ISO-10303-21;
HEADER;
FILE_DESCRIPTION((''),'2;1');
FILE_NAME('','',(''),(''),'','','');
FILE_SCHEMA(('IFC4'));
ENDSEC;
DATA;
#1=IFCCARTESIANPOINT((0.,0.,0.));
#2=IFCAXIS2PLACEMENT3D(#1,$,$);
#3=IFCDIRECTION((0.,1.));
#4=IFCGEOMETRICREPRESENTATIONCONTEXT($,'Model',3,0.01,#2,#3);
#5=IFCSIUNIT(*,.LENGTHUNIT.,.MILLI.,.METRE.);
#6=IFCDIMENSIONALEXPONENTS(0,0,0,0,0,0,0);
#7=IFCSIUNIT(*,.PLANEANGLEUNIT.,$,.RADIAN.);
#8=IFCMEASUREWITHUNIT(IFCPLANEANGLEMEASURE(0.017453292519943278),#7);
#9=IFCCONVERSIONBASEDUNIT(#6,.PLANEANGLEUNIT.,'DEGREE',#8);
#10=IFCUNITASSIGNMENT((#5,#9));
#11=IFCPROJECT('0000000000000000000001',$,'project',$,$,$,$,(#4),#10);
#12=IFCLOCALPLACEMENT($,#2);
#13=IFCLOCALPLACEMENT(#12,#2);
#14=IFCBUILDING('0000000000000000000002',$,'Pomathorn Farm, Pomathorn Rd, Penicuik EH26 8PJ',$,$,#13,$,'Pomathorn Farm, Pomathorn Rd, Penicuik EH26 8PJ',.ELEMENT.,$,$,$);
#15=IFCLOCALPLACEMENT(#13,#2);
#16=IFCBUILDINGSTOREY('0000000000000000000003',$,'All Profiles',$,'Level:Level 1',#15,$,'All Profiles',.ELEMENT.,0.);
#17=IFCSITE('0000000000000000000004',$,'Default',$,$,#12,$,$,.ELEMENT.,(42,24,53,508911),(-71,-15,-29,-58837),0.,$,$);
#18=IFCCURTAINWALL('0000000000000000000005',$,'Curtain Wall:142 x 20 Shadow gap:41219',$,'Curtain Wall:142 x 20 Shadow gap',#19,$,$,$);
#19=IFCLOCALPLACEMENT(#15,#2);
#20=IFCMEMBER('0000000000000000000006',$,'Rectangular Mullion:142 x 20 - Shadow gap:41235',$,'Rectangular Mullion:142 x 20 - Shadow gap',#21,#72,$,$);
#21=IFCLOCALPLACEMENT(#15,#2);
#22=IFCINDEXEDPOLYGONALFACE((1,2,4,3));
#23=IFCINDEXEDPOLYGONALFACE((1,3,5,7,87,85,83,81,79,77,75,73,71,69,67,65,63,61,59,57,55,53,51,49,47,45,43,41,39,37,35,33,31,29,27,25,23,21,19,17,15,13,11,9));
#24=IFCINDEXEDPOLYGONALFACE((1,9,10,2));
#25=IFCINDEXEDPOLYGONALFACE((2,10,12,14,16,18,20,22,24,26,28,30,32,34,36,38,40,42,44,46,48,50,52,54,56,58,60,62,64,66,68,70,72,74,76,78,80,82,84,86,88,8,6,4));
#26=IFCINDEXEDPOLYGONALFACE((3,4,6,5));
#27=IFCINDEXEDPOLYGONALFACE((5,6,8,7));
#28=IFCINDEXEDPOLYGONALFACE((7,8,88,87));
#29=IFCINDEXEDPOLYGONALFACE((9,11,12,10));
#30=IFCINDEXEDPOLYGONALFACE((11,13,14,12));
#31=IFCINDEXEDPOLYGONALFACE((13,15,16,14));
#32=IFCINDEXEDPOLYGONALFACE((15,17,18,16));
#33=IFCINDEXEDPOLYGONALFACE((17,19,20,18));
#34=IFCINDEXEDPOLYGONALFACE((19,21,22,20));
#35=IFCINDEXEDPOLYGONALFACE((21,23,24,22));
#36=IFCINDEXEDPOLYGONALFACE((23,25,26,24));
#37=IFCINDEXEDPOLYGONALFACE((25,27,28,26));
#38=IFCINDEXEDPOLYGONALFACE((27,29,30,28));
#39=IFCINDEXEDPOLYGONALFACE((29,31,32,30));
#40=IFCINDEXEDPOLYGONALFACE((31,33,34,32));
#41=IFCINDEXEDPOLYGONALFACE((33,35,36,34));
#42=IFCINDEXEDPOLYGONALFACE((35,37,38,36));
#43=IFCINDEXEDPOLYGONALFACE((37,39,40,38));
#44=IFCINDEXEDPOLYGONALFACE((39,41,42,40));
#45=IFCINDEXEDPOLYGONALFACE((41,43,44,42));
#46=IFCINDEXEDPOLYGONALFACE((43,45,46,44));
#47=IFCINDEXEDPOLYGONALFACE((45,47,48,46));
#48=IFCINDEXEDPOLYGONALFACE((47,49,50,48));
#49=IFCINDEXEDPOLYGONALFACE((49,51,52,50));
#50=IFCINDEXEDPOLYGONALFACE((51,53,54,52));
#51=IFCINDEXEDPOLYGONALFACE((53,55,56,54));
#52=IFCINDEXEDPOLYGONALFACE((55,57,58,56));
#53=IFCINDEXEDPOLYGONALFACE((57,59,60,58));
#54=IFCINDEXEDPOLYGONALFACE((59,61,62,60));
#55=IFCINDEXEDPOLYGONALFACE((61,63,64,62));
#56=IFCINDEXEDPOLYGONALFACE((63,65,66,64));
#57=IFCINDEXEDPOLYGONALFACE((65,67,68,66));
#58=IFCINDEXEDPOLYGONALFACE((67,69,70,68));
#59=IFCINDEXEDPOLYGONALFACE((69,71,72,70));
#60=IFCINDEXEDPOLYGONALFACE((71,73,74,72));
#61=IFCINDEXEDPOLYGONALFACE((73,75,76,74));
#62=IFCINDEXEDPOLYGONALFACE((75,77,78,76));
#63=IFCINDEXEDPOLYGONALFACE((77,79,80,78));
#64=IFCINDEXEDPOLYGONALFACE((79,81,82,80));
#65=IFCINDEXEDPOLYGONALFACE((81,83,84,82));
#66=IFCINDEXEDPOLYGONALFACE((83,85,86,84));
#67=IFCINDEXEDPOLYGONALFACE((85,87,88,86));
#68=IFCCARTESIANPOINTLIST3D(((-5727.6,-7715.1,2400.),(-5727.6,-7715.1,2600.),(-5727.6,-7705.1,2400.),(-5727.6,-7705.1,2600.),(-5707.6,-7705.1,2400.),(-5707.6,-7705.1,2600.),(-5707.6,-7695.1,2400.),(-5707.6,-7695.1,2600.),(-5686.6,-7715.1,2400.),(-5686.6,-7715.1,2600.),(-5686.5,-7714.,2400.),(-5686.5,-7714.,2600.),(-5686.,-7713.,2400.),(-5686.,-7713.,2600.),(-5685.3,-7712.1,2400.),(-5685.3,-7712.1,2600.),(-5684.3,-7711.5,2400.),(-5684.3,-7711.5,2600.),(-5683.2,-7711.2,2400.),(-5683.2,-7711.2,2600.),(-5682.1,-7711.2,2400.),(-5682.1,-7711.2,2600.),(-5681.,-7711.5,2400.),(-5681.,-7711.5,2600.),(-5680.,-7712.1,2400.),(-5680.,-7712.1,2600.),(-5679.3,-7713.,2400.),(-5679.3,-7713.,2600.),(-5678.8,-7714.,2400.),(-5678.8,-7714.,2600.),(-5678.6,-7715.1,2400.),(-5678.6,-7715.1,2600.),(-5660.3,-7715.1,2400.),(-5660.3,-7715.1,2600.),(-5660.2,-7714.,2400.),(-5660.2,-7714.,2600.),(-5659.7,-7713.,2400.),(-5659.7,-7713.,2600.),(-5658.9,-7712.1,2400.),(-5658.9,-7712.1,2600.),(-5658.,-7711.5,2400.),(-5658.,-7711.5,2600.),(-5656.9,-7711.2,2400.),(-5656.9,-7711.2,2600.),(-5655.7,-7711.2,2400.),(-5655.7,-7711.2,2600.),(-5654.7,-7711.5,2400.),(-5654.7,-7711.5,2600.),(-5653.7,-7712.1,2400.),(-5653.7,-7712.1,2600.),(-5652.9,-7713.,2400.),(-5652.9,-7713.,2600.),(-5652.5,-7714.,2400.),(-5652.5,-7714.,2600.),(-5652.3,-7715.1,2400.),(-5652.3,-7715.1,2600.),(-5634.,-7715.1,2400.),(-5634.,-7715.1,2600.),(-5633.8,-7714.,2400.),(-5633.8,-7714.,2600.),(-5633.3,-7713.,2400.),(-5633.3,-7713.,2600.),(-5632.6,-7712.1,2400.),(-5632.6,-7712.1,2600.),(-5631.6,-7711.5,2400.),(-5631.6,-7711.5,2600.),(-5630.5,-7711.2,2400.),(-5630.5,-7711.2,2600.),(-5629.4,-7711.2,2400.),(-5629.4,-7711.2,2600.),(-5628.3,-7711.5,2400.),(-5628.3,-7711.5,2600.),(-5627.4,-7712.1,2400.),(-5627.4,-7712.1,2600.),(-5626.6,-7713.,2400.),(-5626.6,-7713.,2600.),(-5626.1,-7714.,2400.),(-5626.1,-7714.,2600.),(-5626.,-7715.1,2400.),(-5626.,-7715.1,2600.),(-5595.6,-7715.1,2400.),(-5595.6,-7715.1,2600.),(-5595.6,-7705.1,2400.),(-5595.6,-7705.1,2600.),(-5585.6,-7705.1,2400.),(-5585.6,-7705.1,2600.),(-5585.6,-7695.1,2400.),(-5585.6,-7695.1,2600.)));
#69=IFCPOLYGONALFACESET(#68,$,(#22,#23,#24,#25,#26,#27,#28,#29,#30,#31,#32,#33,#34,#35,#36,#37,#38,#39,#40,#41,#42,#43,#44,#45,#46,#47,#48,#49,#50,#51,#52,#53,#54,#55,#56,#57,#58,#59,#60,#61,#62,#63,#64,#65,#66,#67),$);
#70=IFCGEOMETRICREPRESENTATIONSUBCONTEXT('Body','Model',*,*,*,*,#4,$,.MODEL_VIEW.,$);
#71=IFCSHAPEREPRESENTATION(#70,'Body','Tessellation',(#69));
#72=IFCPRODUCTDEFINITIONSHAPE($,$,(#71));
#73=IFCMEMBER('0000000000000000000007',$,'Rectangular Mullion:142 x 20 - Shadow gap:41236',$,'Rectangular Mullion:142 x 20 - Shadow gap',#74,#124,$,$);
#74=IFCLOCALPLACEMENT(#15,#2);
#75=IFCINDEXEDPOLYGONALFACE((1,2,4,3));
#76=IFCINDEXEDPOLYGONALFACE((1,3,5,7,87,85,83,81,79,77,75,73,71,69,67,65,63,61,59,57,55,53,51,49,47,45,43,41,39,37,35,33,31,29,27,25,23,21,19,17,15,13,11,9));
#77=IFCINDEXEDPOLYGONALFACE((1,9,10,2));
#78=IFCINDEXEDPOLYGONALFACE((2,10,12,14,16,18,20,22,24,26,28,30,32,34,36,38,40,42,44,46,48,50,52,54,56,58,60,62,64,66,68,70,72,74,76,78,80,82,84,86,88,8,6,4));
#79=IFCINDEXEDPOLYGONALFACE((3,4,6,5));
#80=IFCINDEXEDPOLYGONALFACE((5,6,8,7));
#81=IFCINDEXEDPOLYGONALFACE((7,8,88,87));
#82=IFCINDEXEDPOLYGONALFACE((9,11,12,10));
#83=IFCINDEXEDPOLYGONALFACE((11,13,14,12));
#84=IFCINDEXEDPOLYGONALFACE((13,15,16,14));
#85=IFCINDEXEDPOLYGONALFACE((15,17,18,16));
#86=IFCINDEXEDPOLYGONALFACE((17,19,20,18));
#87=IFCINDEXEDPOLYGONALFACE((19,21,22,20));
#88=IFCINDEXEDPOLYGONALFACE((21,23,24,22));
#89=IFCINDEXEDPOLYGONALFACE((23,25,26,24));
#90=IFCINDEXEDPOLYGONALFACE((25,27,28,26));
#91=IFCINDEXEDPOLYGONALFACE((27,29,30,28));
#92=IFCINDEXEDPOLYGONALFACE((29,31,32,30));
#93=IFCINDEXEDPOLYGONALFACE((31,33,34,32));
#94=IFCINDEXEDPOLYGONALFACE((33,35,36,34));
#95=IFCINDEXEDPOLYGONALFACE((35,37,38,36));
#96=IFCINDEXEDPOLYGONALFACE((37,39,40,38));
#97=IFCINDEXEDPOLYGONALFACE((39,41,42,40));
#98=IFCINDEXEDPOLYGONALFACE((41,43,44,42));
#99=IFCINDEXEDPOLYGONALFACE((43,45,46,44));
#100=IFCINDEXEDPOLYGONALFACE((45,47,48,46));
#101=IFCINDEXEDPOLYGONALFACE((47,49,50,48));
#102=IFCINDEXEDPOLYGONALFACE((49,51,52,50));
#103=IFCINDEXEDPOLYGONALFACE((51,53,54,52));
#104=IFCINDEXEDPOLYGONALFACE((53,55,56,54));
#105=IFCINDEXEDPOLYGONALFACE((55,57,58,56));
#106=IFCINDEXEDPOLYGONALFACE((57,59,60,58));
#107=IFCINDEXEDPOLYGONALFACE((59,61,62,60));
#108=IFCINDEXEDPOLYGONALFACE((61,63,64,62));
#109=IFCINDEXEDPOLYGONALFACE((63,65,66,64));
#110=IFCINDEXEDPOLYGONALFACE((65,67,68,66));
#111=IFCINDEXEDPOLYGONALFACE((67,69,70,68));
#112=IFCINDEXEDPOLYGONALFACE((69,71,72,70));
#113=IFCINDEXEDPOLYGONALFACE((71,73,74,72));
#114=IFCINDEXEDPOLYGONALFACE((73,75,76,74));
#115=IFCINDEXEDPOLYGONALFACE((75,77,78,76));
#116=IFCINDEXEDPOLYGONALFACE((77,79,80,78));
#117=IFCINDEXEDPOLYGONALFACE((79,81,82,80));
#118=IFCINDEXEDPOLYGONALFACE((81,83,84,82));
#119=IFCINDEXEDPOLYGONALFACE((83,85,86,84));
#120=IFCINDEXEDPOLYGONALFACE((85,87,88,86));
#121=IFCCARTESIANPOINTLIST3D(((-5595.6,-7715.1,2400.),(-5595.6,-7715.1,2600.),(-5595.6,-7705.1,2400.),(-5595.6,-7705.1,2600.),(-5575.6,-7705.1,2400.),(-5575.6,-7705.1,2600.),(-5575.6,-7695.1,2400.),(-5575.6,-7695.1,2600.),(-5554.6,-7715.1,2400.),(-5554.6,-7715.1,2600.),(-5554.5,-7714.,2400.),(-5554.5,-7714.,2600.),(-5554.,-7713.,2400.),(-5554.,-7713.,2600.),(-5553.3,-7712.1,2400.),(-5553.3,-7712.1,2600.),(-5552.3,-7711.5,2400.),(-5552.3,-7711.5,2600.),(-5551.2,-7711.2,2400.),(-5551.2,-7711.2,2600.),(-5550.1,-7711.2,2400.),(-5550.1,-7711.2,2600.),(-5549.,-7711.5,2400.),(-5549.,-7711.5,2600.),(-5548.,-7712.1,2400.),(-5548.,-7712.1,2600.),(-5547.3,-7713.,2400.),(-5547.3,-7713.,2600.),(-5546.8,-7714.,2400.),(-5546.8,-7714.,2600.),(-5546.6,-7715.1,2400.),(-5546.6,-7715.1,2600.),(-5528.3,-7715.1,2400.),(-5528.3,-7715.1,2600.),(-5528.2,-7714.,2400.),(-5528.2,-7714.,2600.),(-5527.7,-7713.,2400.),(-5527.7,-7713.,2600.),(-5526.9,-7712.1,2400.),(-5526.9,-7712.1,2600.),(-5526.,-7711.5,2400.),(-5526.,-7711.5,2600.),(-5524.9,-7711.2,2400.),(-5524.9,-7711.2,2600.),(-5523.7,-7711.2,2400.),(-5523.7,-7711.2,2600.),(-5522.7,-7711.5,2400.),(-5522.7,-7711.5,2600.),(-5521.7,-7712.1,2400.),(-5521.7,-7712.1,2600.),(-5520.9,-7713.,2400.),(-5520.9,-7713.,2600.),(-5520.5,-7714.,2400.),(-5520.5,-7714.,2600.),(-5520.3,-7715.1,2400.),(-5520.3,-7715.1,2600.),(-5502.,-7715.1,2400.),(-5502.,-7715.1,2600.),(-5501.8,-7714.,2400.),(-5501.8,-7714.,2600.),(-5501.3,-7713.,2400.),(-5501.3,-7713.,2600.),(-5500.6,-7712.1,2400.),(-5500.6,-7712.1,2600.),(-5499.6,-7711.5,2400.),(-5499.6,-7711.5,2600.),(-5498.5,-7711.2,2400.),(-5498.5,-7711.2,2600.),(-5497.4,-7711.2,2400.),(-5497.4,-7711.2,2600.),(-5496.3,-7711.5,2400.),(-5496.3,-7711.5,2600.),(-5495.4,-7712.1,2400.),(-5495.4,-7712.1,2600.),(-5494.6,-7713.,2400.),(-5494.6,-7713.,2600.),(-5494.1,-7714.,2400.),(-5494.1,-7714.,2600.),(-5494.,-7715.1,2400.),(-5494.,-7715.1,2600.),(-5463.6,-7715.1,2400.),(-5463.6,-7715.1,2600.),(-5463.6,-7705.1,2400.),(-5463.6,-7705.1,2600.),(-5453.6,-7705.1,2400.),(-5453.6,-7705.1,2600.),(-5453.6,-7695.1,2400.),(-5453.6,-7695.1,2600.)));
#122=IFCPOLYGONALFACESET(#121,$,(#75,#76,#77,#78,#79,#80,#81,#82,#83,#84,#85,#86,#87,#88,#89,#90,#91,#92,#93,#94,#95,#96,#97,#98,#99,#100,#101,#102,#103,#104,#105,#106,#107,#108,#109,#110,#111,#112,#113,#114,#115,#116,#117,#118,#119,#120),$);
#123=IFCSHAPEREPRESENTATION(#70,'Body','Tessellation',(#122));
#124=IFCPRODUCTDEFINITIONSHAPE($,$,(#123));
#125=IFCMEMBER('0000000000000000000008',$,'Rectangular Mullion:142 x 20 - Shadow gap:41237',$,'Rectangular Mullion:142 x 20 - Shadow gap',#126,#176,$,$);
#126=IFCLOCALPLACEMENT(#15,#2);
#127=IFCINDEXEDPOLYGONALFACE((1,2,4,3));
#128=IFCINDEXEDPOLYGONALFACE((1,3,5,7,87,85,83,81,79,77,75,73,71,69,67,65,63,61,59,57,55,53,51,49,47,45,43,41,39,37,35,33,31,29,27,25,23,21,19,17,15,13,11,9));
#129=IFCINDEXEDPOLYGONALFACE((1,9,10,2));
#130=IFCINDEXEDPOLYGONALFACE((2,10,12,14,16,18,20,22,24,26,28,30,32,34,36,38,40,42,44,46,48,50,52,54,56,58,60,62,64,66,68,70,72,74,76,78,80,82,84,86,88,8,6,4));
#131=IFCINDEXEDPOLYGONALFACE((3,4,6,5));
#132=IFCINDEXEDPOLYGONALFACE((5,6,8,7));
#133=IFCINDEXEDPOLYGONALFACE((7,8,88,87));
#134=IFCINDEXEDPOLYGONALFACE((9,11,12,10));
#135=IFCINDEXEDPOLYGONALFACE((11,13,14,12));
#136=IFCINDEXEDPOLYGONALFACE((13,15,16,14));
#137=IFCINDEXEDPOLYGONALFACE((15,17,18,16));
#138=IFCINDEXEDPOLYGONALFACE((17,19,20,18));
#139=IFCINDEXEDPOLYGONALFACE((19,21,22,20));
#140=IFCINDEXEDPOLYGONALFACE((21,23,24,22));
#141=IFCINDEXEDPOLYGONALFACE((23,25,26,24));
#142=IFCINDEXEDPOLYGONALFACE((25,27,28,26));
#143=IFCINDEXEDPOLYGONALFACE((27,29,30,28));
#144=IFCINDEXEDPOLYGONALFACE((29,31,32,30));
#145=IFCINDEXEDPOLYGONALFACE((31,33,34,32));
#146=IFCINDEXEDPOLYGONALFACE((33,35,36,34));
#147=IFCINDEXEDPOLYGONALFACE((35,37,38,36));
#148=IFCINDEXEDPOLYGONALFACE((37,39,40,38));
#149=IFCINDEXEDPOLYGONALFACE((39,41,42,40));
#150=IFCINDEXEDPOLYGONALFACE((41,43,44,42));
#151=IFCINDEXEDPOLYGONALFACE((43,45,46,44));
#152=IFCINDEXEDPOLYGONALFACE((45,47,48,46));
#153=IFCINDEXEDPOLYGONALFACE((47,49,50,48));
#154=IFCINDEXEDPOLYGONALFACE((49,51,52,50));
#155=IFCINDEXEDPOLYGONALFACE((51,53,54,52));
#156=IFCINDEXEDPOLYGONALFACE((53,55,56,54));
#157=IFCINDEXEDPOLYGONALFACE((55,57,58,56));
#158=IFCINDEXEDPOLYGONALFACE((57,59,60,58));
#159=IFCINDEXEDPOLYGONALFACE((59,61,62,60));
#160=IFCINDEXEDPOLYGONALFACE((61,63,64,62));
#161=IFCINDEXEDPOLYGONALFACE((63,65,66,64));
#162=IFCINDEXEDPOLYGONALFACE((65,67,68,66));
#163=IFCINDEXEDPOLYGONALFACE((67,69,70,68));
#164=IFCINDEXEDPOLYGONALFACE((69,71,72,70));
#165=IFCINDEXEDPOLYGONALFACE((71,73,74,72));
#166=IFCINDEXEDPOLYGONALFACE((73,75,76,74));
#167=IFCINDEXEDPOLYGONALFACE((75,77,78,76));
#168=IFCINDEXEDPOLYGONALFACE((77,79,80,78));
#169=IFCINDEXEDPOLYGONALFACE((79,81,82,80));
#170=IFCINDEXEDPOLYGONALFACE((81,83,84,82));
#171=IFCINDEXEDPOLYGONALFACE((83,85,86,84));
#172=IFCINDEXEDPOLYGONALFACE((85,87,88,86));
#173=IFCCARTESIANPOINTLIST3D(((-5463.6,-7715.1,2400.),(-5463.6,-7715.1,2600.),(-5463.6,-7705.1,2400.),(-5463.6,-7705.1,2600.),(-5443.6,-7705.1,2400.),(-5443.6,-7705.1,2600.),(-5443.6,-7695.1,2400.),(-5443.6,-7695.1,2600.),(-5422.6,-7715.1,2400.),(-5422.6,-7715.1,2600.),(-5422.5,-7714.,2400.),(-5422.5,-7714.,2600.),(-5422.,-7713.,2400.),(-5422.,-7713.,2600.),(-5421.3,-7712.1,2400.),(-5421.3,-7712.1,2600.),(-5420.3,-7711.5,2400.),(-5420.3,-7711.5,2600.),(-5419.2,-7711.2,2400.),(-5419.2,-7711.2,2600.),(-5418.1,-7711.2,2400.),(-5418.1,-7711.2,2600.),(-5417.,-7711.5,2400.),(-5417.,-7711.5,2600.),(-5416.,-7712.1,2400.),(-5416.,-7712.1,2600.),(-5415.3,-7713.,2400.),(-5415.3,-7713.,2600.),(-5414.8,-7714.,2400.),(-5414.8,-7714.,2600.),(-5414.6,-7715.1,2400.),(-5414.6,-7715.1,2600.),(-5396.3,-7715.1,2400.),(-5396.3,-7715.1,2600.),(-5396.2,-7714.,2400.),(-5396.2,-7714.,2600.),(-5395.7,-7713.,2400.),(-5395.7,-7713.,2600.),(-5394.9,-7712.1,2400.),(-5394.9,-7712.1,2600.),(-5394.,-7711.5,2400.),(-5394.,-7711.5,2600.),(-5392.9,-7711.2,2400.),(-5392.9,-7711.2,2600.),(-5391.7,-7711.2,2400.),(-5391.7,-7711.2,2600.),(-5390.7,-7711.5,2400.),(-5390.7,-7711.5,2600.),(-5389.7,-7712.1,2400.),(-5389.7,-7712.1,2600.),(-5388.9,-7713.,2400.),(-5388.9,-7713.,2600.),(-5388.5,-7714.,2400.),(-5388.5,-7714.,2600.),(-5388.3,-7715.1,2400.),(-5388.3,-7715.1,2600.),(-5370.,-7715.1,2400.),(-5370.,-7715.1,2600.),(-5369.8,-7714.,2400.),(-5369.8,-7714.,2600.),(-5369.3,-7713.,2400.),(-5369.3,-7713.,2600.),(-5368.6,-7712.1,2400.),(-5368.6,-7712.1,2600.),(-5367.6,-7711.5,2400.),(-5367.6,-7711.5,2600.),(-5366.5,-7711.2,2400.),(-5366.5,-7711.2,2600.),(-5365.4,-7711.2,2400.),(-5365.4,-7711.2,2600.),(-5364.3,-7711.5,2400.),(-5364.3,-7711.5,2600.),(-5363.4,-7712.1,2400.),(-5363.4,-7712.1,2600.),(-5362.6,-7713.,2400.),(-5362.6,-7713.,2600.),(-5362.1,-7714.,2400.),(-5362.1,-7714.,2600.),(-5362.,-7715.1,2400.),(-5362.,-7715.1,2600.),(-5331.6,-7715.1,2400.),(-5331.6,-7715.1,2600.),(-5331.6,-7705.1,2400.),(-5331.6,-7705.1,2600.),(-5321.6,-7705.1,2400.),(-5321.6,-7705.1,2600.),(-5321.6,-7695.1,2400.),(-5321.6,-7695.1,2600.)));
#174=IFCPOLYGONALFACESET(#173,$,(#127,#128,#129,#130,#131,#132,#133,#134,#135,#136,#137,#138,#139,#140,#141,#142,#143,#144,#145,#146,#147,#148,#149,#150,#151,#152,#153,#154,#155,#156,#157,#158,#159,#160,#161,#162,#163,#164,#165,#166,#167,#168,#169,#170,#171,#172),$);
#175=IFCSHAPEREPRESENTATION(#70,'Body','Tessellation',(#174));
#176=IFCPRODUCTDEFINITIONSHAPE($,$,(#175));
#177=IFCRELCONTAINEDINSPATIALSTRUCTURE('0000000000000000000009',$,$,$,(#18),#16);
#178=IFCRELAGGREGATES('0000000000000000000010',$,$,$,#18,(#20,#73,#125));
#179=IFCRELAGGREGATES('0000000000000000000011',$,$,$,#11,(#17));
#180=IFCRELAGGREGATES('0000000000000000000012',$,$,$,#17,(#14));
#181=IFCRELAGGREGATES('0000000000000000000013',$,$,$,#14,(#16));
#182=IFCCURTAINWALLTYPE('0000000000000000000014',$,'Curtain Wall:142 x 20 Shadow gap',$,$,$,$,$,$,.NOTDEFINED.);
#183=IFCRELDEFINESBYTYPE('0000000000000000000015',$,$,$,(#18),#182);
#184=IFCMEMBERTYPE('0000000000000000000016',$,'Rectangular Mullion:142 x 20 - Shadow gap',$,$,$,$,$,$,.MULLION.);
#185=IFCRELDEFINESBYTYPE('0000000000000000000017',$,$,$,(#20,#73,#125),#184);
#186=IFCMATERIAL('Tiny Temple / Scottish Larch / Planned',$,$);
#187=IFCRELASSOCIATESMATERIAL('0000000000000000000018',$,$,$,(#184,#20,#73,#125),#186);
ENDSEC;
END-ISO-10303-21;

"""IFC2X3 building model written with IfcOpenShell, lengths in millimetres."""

from ifc_helpers import new_model, entity, si_unit, converted_unit, direction, frame, frame_2d, origin, place, context, subcontext, project, spatial, polyline, circle_curve, parameter, trimmed, segment, composite_curve, outline, extrude, source, transform, mapped, material, type_object, type_shapes, element, aggregate, save


model = new_model("IFC2X3")

# Units and contexts
model_context = context("Model", 3, precision=0.01, world=origin(), true_north=direction((0.0, 1.0)))
body_context = subcontext(model_context, "Body", "Model", "MODEL_VIEW")
ifc_project = project(units=[si_unit("LENGTHUNIT", "METRE", prefix="MILLI"), converted_unit("PLANEANGLEUNIT", "DEGREE", entity("IfcPlaneAngleMeasure", 0.017453292519943278), si_unit("PLANEANGLEUNIT", "RADIAN"), dimensions=[0, 0, 0, 0, 0, 0, 0])], contexts=[model_context])

# Site, building, storey
site_placement = place(None, origin())
site = spatial("IfcSite", under=ifc_project, at=site_placement, Name="Default", CompositionType="ELEMENT", RefLatitude=(42, 24, 53, 508911), RefLongitude=(-71, -15, -29, -58837), RefElevation=0.0)
building_placement = place(site_placement, origin())
building = spatial("IfcBuilding", under=site, at=building_placement, Name="Pomathorn Farm, Pomathorn Rd, Penicuik EH26 8PJ", LongName="Pomathorn Farm, Pomathorn Rd, Penicuik EH26 8PJ", CompositionType="ELEMENT")
storey_placement = place(building_placement, origin())
storey = spatial("IfcBuildingStorey", under=building, at=storey_placement, Name="All Profiles", ObjectType="Level:Level 1", LongName="All Profiles", CompositionType="ELEMENT", Elevation=0.0)

# Curtain wall, members
curtain_wall_type_1 = type_object("IfcCurtainWallType", Name="Curtain Wall:142 x 20 Shadow gap", PredefinedType="NOTDEFINED")
curtain_wall_1_placement = place(storey_placement, origin())
curtain_wall_1 = element("IfcCurtainWall", 1, at=curtain_wall_1_placement, inside=storey, type_object=curtain_wall_type_1, Name="Curtain Wall:142 x 20 Shadow gap:41219", ObjectType="Curtain Wall:142 x 20 Shadow gap")
ifc_material = material(Name="Tiny Temple / Scottish Larch / Planned")
member_type_1 = type_object("IfcMemberType", Name="Rectangular Mullion:142 x 20 - Shadow gap", PredefinedType="MULLION", material=ifc_material)
shared_shape_1 = source(origin(), body_context, "Body", "SweptSolid", [
    extrude(outline(composite_curve([segment(polyline([(29.1, -5.7), (59.4, -5.7)]), True, "CONTINUOUS"), segment(polyline([(59.4, -5.7), (59.4, 4.3)]), True, "CONTINUOUS"), segment(polyline([(59.4, 4.3), (69.4, 4.3)]), True, "CONTINUOUS"), segment(polyline([(69.4, 4.3), (69.4, 14.3)]), True, "CONTINUOUS"), segment(polyline([(69.4, 14.3), (-52.6, 14.3)]), True, "CONTINUOUS"), segment(polyline([(-52.6, 14.3), (-52.6, 4.3)]), True, "CONTINUOUS"), segment(polyline([(-52.6, 4.3), (-72.6, 4.3)]), True, "CONTINUOUS"), segment(polyline([(-72.6, 4.3), (-72.6, -5.7)]), True, "CONTINUOUS"), segment(polyline([(-72.6, -5.7), (-31.6, -5.7)]), True, "CONTINUOUS"), segment(trimmed(circle_curve(frame_2d((-27.6, -5.7), x_axis=(1.0, 0.0)), 4.0), [parameter(360.0)], [parameter(180.0)], True, "PARAMETER"), False, "CONTINUOUS"), segment(polyline([(-23.6, -5.7), (-5.2, -5.7)]), True, "CONTINUOUS"), segment(trimmed(circle_curve(frame_2d((-1.2, -5.7), x_axis=(1.0, 0.0)), 4.0), [parameter(360.0)], [parameter(180.0)], True, "PARAMETER"), False, "CONTINUOUS"), segment(polyline([(2.8, -5.7), (21.1, -5.7)]), True, "CONTINUOUS"), segment(trimmed(circle_curve(frame_2d((25.1, -5.7), x_axis=(1.0, 0.0)), 4.0), [parameter(360.0)], [parameter(180.0)], True, "PARAMETER"), False, "CONTINUOUS")], self_intersect=False)), frame((-69.4, -5.7, -200.0), z_axis=(0.0, 0.0, -1.0), x_axis=(1.0, 0.0, 0.0)), (0.0, 0.0, -1.0), 200.0),
])
type_shapes(member_type_1, [shared_shape_1])
member_1_placement = place(curtain_wall_1_placement, frame((-5585.6, -7715.1, 2400.0), z_axis=(0.0, 0.0, -1.0), x_axis=(1.0, 0.0, 0.0)))
member_1 = element("IfcMember", 2, at=member_1_placement, type_object=member_type_1, material=ifc_material, Name="Rectangular Mullion:142 x 20 - Shadow gap:41235", ObjectType="Rectangular Mullion:142 x 20 - Shadow gap", context=body_context, shape_type="MappedRepresentation", body=[
    mapped(shared_shape_1, transform((0.0, 0.0, 0.0), scale=1.0)),
])
member_2_placement = place(curtain_wall_1_placement, frame((-5453.6, -7715.1, 2400.0), z_axis=(0.0, 0.0, -1.0), x_axis=(1.0, 0.0, 0.0)))
member_2 = element("IfcMember", 3, at=member_2_placement, type_object=member_type_1, material=ifc_material, Name="Rectangular Mullion:142 x 20 - Shadow gap:41236", ObjectType="Rectangular Mullion:142 x 20 - Shadow gap", context=body_context, shape_type="MappedRepresentation", body=[
    mapped(shared_shape_1, transform((0.0, 0.0, 0.0), scale=1.0)),
])
member_3_placement = place(curtain_wall_1_placement, frame((-5321.6, -7715.1, 2400.0), z_axis=(0.0, 0.0, -1.0), x_axis=(1.0, 0.0, 0.0)))
member_3 = element("IfcMember", 4, at=member_3_placement, type_object=member_type_1, material=ifc_material, Name="Rectangular Mullion:142 x 20 - Shadow gap:41237", ObjectType="Rectangular Mullion:142 x 20 - Shadow gap", context=body_context, shape_type="MappedRepresentation", body=[
    mapped(shared_shape_1, transform((0.0, 0.0, 0.0), scale=1.0)),
])
aggregate(curtain_wall_1, [member_1, member_2, member_3])

save(model, "model.ifc")
